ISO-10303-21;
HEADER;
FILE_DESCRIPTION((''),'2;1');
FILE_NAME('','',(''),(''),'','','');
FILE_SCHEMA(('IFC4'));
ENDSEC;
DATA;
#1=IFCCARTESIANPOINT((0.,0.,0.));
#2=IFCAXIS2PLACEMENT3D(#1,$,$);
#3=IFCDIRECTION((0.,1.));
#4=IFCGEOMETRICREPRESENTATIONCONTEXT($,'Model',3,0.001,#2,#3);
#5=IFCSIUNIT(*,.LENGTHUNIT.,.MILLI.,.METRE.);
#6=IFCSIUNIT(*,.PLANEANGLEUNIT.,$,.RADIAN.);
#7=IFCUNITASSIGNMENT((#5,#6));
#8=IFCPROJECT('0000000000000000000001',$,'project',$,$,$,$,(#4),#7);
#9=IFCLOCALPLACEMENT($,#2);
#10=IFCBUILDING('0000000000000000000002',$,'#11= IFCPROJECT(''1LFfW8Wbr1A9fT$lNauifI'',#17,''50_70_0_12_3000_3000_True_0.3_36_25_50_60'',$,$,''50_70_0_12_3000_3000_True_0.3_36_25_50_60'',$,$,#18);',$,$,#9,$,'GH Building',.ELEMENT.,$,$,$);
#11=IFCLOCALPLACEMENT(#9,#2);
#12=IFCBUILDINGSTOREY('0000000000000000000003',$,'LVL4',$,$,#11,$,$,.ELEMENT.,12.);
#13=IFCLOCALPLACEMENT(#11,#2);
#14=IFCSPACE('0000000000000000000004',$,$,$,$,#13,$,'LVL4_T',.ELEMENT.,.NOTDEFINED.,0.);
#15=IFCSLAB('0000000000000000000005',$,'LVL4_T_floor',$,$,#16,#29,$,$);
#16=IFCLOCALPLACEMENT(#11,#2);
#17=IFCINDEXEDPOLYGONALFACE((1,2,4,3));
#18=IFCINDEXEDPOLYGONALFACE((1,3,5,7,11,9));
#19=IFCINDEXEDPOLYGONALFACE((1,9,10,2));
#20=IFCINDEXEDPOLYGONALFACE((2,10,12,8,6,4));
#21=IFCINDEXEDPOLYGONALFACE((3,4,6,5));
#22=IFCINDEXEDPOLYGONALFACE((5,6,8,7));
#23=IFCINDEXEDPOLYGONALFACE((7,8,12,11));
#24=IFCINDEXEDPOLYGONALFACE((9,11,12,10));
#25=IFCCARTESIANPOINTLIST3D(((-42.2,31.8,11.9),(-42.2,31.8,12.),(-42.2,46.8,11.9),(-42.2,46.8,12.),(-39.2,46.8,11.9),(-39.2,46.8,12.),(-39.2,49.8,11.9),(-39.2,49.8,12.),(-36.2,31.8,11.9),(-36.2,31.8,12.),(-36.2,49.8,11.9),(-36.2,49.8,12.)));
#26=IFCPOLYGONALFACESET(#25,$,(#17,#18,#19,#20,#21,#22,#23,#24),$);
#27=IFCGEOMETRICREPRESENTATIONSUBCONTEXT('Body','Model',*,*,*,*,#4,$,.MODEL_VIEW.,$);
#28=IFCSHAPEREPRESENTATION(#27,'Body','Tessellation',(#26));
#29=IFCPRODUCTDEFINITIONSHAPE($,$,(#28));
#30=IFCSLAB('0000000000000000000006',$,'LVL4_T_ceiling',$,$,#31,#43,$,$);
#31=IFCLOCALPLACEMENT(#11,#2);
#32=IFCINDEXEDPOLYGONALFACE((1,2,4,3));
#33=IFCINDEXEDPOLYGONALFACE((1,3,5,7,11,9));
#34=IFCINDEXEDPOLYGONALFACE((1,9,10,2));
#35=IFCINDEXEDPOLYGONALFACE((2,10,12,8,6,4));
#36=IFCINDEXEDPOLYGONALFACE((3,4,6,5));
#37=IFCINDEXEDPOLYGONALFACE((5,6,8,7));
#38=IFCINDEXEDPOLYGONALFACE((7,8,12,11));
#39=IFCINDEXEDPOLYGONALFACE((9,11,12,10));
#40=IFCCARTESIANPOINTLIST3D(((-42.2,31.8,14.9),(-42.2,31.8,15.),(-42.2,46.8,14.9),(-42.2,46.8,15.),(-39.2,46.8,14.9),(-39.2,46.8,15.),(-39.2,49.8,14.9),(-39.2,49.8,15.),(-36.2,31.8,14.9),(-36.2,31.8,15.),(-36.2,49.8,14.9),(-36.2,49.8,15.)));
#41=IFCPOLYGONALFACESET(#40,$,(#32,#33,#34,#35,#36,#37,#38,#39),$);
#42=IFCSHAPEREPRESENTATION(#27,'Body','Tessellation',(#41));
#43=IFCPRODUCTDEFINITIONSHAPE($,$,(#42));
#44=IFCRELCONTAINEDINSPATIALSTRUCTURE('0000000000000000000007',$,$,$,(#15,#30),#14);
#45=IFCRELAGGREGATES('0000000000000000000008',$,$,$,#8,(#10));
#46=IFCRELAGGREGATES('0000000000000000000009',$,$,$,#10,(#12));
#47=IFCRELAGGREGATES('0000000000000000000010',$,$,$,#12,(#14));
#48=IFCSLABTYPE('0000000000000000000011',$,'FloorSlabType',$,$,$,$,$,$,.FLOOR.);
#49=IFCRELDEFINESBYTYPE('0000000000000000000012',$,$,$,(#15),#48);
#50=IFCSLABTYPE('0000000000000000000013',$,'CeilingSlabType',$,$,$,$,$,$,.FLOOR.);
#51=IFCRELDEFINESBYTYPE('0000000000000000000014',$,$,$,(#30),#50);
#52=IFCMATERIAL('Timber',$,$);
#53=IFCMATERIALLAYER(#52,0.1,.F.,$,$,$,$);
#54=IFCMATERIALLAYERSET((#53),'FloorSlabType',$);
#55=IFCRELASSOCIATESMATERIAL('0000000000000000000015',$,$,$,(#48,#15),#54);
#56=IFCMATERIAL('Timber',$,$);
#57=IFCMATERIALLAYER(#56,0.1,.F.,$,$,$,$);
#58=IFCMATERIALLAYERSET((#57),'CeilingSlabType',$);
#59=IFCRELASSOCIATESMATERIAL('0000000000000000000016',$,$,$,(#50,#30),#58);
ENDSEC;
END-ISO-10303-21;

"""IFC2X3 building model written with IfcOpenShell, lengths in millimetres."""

from ifc_helpers import new_model, si_unit, direction, frame, origin, place, context, subcontext, project, spatial, polyline, outline, extrude, material, layer, layer_set, layer_usage, type_object, element, save


model = new_model("IFC2X3")

# Units and contexts
model_context = context("Model", 3, precision=0.001, world=origin(), true_north=direction((0.0, 1.0)))
body_context = subcontext(model_context, "Body", "Model", "MODEL_VIEW")
ifc_project = project(units=[si_unit("LENGTHUNIT", "METRE", prefix="MILLI"), si_unit("PLANEANGLEUNIT", "RADIAN")], contexts=[model_context])

# Building, storey, space
building_placement = place(None, origin())
building = spatial("IfcBuilding", under=ifc_project, at=building_placement, Name="#11= IFCPROJECT('1LFfW8Wbr1A9fT$lNauifI',#17,'50_70_0_12_3000_3000_True_0.3_36_25_50_60',$,$,'50_70_0_12_3000_3000_True_0.3_36_25_50_60',$,$,#18);", LongName="GH Building", CompositionType="ELEMENT")
storey_placement = place(building_placement, origin())
storey = spatial("IfcBuildingStorey", under=building, at=storey_placement, Name="LVL4", CompositionType="ELEMENT", Elevation=12.0)
space_placement = place(storey_placement, origin())
space = spatial("IfcSpace", under=storey, at=space_placement, LongName="LVL4_T", CompositionType="ELEMENT", InteriorOrExteriorSpace="NOTDEFINED", ElevationWithFlooring=0.0)

# Slabs
ifc_material_1 = material(Name="Timber")
ifc_layer_1 = layer(ifc_material_1, 0.1, ventilated=False)
ifc_layer_set_1 = layer_set([ifc_layer_1], Name="FloorSlabType")
ifc_layer_usage_1 = layer_usage(ifc_layer_set_1, "AXIS3", "NEGATIVE", -0.1)
slab_type_1 = type_object("IfcSlabType", Name="FloorSlabType", PredefinedType="FLOOR", material=ifc_layer_set_1)
slab_1_placement = place(space_placement, frame((-39.2, 40.8, 11.9)))
element("IfcSlab", 1, at=slab_1_placement, inside=space, type_object=slab_type_1, material=ifc_layer_usage_1, Name="LVL4_T_floor", context=body_context, shape_type="SweptSolid", body=[
    extrude(outline(polyline([(3.0, -9.0), (3.0, 9.0), (0.0, 9.0), (0.0, 6.0), (-3.0, 6.0), (-3.0, -9.0), (3.0, -9.0)])), origin(), (0.0, 0.0, 1.0), 0.1),
])
ifc_material_2 = material(Name="Timber")
ifc_layer_2 = layer(ifc_material_2, 0.1, ventilated=False)
ifc_layer_set_2 = layer_set([ifc_layer_2], Name="CeilingSlabType")
ifc_layer_usage_2 = layer_usage(ifc_layer_set_2, "AXIS3", "NEGATIVE", -0.1)
slab_type_2 = type_object("IfcSlabType", Name="CeilingSlabType", PredefinedType="FLOOR", material=ifc_layer_set_2)
slab_2_placement = place(space_placement, frame((-39.2, 40.8, 14.9)))
element("IfcSlab", 2, at=slab_2_placement, inside=space, type_object=slab_type_2, material=ifc_layer_usage_2, Name="LVL4_T_ceiling", context=body_context, shape_type="SweptSolid", body=[
    extrude(outline(polyline([(3.0, -9.0), (3.0, 9.0), (0.0, 9.0), (0.0, 6.0), (-3.0, 6.0), (-3.0, -9.0), (3.0, -9.0)])), origin(), (0.0, 0.0, 1.0), 0.1),
])

save(model, "model.ifc")
